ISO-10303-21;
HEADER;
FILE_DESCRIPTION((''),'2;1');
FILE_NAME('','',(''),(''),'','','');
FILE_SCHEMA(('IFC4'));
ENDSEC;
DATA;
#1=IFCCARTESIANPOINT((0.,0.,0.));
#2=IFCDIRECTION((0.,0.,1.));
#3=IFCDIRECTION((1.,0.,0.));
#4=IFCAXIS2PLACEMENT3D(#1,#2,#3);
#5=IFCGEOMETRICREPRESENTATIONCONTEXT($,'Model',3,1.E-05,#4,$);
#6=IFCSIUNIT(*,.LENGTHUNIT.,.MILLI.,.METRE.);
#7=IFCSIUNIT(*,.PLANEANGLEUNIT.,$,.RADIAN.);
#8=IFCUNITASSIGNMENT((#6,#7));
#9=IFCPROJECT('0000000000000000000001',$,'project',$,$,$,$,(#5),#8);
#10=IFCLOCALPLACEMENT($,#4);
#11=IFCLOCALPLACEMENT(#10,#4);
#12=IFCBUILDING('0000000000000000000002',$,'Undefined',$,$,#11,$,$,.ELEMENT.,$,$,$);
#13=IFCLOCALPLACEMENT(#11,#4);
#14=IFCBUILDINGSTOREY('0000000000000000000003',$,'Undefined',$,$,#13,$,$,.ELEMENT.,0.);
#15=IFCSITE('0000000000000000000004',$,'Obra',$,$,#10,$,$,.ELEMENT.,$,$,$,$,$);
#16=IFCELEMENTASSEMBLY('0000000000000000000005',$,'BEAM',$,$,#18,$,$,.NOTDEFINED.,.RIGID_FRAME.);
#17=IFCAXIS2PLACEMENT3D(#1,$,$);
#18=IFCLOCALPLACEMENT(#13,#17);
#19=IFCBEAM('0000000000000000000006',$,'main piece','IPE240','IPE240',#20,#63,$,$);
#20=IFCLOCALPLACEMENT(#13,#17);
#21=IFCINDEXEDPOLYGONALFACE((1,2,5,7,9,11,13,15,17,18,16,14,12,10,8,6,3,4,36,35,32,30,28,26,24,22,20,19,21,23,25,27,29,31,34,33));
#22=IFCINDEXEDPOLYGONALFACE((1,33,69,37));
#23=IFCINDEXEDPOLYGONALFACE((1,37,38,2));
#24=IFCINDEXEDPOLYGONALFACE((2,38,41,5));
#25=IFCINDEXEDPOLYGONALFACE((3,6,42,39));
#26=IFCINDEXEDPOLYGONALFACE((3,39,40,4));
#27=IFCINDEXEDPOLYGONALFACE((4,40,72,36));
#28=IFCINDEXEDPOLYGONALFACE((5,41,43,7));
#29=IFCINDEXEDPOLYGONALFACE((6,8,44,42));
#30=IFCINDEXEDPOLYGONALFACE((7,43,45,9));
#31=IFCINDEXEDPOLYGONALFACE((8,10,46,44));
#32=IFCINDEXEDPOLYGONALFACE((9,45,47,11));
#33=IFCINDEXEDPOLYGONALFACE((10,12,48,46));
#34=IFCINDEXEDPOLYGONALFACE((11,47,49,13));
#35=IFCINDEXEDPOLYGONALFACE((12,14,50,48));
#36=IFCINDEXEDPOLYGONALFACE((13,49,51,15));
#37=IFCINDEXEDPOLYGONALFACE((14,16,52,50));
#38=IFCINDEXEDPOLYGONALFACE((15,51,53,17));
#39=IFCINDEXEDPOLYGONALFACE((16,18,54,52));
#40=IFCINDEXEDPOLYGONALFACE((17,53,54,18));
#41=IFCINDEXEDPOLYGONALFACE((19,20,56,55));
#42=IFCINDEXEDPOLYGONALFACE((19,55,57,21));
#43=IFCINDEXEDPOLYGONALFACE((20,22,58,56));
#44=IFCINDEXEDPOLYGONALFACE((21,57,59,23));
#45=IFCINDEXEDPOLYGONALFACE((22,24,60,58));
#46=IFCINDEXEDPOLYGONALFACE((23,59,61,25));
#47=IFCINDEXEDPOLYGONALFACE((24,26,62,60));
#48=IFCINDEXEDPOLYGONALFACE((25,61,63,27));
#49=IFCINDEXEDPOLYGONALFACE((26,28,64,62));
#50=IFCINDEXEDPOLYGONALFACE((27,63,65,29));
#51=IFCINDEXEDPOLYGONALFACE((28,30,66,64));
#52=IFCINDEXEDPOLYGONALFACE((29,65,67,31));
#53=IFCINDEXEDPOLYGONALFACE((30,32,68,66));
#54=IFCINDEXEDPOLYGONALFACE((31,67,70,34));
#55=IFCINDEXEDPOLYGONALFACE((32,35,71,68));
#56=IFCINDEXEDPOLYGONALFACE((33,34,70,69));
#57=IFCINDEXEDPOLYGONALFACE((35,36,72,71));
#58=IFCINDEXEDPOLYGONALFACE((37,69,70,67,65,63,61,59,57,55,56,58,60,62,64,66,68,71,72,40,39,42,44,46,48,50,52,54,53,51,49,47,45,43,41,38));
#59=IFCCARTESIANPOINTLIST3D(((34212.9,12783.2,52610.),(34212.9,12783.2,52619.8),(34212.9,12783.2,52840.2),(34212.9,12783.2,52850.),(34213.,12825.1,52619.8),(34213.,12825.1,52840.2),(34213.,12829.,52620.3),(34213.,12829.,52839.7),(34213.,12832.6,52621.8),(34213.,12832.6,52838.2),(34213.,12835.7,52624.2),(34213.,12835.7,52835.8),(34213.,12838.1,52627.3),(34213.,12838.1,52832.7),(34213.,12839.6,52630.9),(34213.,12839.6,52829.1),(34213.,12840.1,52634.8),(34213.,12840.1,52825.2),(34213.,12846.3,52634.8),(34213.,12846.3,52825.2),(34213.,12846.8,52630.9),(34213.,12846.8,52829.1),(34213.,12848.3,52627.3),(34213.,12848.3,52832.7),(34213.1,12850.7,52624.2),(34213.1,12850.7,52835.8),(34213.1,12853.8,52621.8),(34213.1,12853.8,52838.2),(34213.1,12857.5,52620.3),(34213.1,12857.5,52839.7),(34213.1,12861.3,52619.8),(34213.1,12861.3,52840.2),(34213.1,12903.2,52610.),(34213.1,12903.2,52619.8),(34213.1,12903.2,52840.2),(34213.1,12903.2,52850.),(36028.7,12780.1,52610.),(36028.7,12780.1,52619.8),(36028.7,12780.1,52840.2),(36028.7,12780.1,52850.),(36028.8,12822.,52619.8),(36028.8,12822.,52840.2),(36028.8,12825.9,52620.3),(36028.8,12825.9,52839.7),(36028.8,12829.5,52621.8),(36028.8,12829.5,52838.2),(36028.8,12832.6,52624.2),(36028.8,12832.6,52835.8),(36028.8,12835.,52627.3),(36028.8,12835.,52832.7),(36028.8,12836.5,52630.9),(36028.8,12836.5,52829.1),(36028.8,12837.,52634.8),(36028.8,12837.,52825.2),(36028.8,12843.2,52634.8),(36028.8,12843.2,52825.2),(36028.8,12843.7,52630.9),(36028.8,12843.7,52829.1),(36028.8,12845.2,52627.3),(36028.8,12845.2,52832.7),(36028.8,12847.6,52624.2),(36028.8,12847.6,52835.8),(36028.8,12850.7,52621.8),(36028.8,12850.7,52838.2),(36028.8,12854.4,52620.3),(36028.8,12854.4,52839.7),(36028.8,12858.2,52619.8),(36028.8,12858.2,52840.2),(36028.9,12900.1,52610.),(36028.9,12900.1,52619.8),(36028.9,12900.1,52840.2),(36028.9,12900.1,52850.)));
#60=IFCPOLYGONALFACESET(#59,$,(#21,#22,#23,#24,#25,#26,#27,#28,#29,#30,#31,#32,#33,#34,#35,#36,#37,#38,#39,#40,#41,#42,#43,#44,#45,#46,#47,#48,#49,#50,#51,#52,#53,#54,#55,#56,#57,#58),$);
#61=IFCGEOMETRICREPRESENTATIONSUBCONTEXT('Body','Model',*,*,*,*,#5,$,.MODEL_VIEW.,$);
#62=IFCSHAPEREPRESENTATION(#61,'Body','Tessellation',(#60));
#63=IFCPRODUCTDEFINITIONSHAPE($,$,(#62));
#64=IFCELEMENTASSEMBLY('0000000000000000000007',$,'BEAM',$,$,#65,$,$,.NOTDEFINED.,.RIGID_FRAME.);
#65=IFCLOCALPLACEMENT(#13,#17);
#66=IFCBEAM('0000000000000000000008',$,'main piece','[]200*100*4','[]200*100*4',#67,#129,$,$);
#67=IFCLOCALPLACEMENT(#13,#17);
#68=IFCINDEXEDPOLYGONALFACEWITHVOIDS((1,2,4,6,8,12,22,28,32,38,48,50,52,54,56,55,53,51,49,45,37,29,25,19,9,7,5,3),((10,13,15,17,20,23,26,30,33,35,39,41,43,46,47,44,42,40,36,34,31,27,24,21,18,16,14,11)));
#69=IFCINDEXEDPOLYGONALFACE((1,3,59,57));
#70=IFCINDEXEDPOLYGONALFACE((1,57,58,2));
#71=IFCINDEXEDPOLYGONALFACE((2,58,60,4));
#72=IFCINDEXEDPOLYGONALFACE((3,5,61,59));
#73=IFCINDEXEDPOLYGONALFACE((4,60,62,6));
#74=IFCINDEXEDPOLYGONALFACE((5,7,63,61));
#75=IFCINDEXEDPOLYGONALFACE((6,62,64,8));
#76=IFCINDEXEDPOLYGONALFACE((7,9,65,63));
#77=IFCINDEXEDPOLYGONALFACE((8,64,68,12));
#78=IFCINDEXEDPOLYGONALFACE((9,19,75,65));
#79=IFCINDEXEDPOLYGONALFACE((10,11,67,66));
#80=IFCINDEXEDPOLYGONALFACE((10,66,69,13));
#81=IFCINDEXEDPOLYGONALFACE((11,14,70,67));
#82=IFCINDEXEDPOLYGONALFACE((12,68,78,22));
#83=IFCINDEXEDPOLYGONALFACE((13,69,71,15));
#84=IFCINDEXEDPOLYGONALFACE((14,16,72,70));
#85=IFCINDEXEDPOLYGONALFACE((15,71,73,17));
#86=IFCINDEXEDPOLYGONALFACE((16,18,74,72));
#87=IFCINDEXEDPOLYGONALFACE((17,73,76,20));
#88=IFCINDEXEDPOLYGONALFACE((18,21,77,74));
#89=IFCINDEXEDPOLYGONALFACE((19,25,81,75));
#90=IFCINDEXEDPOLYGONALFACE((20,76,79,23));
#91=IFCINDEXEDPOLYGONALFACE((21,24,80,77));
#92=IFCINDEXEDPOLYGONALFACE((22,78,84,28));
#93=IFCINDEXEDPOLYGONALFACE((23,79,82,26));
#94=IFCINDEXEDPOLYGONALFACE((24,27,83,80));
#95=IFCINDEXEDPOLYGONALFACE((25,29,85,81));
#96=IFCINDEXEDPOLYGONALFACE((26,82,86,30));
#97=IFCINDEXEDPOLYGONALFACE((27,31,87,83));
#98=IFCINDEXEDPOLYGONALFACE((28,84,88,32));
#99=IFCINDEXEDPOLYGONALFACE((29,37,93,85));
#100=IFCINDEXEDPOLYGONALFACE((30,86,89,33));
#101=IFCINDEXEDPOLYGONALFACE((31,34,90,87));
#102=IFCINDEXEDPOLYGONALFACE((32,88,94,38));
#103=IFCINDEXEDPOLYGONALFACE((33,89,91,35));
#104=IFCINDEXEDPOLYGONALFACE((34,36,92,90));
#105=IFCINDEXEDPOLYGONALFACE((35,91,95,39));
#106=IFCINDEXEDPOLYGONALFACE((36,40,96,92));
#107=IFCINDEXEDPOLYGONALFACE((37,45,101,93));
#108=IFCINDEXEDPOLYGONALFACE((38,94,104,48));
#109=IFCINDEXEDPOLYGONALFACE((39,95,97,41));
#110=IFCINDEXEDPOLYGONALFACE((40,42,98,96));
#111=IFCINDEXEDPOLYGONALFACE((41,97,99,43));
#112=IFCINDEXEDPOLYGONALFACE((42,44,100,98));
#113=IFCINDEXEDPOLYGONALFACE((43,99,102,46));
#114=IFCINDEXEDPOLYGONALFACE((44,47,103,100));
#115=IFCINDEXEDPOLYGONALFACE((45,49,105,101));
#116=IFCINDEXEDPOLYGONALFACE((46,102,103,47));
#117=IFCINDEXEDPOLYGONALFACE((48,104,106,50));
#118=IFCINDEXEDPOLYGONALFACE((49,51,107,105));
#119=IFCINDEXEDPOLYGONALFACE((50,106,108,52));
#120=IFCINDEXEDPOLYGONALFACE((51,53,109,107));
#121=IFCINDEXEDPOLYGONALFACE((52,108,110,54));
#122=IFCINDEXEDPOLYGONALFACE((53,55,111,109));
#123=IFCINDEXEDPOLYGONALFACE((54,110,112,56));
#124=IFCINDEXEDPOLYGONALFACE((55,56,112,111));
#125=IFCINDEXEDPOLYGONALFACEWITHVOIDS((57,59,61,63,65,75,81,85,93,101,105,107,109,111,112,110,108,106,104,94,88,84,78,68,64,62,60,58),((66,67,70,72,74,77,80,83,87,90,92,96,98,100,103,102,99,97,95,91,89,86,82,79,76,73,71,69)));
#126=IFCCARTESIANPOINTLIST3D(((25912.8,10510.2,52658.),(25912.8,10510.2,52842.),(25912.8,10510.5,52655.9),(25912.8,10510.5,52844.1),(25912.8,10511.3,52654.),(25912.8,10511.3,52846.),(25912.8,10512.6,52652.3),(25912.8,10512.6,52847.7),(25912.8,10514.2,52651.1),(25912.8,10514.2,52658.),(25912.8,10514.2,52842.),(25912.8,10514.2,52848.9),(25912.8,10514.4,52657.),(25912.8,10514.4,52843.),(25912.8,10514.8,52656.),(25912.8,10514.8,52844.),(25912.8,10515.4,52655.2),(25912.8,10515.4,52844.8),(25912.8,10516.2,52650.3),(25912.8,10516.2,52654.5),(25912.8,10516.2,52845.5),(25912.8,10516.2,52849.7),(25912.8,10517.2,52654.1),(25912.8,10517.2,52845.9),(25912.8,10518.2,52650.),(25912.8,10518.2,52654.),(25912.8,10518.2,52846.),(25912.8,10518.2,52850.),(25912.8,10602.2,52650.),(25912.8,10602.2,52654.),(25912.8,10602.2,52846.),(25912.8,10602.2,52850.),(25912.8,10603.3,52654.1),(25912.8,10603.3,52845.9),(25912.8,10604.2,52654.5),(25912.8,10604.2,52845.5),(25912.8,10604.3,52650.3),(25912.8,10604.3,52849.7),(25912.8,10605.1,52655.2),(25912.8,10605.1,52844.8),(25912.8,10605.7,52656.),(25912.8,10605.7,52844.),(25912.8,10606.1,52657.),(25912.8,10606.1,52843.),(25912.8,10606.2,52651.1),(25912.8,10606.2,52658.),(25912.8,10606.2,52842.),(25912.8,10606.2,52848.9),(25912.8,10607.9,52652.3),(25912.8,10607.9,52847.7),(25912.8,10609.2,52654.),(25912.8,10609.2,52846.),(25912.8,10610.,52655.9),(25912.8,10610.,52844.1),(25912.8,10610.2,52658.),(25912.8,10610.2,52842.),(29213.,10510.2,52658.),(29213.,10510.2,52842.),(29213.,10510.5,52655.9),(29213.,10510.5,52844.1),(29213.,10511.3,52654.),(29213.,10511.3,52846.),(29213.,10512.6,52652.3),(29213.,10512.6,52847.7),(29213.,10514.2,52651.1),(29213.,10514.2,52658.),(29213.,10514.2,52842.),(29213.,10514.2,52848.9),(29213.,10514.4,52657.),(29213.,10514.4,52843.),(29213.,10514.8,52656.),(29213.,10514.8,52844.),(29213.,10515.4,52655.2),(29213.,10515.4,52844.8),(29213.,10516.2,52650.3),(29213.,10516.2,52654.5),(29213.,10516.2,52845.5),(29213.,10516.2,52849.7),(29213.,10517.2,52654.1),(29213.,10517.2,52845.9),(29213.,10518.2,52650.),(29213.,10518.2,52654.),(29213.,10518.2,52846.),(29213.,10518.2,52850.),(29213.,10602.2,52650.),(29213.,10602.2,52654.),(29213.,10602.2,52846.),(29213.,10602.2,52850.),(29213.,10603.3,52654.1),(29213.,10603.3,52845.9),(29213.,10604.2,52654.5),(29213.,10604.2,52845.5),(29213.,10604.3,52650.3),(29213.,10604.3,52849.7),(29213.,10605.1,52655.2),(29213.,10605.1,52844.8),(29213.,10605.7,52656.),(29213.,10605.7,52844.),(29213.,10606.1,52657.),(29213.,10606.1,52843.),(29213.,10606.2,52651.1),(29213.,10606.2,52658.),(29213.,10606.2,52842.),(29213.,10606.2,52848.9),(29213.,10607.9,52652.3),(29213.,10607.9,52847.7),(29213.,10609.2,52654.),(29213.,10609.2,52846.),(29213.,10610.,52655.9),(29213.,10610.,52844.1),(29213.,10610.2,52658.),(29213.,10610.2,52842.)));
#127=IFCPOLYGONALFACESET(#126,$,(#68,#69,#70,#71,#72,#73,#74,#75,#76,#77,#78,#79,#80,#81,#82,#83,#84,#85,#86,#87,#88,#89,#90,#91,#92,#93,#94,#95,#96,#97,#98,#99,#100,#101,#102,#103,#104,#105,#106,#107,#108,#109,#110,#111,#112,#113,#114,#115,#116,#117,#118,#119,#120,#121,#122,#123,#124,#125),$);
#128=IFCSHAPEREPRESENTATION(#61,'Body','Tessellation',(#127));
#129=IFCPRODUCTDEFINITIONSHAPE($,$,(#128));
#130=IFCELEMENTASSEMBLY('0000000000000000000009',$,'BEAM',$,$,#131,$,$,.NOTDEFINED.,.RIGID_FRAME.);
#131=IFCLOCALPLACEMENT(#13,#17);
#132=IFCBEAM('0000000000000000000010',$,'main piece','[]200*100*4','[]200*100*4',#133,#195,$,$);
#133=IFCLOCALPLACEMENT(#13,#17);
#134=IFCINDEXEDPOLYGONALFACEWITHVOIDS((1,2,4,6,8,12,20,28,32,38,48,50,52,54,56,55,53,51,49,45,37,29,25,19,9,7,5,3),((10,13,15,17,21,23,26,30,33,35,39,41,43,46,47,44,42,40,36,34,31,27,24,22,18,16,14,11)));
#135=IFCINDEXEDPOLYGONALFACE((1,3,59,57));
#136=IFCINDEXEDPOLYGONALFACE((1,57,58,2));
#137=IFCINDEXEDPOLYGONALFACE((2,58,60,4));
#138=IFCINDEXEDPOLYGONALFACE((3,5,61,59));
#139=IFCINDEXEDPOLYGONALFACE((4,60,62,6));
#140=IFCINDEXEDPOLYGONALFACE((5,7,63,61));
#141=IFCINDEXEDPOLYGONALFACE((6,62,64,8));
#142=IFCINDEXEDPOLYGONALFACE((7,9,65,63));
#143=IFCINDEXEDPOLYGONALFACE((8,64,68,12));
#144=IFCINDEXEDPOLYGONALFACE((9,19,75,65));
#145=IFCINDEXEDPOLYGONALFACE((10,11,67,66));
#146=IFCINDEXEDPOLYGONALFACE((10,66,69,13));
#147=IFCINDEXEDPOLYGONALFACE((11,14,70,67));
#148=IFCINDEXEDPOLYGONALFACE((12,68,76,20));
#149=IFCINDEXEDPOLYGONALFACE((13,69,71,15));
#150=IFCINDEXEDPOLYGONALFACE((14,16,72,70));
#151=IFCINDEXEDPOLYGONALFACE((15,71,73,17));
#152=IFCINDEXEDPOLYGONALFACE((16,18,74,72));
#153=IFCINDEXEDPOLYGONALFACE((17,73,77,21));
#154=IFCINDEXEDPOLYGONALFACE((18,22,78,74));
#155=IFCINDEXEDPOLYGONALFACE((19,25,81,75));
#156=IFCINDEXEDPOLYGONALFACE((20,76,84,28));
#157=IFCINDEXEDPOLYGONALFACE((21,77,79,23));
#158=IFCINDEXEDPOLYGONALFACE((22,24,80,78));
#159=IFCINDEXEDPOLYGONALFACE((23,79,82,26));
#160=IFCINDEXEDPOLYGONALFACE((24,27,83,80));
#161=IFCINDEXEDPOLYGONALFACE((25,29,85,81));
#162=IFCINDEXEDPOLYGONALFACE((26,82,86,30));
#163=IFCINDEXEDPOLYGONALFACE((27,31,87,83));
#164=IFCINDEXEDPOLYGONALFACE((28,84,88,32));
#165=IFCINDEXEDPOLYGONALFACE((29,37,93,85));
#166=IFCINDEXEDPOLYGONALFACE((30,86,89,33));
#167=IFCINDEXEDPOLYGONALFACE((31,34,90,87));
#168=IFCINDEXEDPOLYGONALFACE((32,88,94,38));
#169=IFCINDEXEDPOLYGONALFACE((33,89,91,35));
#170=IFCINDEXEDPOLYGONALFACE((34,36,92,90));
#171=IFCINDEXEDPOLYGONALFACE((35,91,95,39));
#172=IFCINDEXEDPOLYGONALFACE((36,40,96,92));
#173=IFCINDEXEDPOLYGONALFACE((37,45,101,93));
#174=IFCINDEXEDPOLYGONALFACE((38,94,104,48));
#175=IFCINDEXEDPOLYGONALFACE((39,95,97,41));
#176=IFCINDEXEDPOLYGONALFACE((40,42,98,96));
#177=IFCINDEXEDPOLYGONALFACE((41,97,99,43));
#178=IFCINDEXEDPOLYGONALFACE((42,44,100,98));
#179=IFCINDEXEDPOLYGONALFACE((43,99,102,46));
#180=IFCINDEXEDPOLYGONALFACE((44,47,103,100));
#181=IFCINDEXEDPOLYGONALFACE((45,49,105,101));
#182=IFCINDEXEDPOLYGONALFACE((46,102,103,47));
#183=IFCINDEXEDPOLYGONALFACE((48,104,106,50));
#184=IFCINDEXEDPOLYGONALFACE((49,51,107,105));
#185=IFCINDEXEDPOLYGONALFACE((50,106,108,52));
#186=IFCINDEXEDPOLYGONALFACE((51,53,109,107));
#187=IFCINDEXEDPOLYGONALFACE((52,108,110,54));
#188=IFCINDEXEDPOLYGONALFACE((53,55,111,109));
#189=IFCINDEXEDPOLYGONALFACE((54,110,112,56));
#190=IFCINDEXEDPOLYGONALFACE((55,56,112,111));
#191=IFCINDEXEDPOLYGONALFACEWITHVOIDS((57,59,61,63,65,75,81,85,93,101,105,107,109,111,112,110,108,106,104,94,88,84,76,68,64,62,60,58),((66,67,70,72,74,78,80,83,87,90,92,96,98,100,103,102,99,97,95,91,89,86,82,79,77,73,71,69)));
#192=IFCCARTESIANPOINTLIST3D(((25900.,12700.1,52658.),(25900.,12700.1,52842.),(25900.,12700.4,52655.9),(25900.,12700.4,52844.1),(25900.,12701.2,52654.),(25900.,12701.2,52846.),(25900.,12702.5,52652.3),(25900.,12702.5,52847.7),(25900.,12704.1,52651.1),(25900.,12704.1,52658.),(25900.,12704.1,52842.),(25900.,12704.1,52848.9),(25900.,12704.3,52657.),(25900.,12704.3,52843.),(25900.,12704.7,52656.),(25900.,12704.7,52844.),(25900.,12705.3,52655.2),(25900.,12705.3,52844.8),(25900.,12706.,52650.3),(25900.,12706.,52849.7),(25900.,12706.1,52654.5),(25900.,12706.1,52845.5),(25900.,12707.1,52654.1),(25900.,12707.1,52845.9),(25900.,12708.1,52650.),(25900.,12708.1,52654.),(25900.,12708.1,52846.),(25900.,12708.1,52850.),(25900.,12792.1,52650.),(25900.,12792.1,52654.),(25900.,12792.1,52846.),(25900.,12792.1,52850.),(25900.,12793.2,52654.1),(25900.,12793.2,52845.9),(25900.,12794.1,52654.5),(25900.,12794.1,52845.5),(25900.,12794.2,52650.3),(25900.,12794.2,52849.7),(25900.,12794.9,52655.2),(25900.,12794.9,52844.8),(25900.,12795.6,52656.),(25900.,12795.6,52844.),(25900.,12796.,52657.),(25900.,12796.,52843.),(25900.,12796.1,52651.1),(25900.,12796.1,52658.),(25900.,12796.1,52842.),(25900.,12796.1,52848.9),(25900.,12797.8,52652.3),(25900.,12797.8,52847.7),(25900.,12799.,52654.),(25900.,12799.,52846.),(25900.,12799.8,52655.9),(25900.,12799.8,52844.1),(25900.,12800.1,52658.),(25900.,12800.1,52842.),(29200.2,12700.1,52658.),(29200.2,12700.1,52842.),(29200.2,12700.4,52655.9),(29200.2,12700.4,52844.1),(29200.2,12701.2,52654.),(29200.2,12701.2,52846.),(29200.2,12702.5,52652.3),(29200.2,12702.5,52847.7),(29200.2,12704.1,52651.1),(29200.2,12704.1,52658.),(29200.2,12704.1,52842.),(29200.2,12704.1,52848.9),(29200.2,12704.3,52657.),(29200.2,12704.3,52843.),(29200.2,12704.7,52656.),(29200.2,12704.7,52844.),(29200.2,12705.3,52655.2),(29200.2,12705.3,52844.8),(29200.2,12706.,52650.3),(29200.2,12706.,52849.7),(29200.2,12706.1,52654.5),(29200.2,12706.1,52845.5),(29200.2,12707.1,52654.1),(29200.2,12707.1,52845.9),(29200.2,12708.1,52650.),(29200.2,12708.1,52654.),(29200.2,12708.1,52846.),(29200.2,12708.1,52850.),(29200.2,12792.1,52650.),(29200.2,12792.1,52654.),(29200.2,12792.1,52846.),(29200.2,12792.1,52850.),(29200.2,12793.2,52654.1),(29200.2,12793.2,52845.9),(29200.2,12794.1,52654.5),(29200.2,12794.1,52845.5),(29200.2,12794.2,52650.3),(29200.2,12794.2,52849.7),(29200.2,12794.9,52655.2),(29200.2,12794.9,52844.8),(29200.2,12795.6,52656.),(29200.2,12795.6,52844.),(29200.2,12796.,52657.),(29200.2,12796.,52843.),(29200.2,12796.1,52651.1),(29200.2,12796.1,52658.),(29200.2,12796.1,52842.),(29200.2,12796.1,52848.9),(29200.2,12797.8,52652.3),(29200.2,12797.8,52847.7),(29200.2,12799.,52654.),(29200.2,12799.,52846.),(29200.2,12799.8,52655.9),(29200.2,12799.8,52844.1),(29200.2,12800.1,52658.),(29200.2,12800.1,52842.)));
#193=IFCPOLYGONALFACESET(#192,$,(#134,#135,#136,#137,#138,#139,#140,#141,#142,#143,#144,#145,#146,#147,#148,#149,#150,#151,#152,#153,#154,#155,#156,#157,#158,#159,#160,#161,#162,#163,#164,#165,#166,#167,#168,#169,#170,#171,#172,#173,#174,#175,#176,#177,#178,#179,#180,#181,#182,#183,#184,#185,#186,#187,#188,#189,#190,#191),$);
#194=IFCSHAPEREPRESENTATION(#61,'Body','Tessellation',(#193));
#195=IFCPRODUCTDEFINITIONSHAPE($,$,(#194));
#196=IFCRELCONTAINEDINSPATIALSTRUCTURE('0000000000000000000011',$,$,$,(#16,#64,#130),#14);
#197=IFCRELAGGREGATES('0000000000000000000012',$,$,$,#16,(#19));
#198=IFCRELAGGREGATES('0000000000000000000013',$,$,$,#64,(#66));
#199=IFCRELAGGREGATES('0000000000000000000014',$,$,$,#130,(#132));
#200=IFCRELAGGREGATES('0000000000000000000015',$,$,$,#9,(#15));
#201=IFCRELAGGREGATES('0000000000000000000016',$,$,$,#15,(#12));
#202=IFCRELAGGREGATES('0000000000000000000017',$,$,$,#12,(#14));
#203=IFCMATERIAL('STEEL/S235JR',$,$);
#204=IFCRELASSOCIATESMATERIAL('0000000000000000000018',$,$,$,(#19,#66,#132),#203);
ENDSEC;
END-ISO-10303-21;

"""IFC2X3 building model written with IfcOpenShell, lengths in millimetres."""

from ifc_helpers import new_model, si_unit, frame, origin_with_axes, origin_2d_with_axis, place, context, subcontext, project, spatial, hollow_rectangle, i_section, extrude, material, element, aggregate, save


model = new_model("IFC2X3")

# Units and contexts
model_context = context("Model", 3, precision=1e-05, world=origin_with_axes())
body_context = subcontext(model_context, "Body", "Model", "MODEL_VIEW")
ifc_project = project(units=[si_unit("LENGTHUNIT", "METRE", prefix="MILLI"), si_unit("PLANEANGLEUNIT", "RADIAN")], contexts=[model_context])

# Site, building, storey
site_placement = place(None, origin_with_axes())
site = spatial("IfcSite", under=ifc_project, at=site_placement, Name="Obra", CompositionType="ELEMENT")
building_placement = place(site_placement, origin_with_axes())
building = spatial("IfcBuilding", under=site, at=building_placement, Name="Undefined", CompositionType="ELEMENT")
storey_placement = place(building_placement, origin_with_axes())
storey = spatial("IfcBuildingStorey", under=building, at=storey_placement, Name="Undefined", CompositionType="ELEMENT", Elevation=0.0)

# Shared definitions
ifc_material_1 = material(Name="STEEL/S235JR")

# Element assemblies, beams
assembly_1_placement = place(storey_placement, origin_with_axes())
assembly_1 = element("IfcElementAssembly", 1, at=assembly_1_placement, inside=storey, Name="BEAM", AssemblyPlace="NOTDEFINED", PredefinedType="RIGID_FRAME")
beam_1_placement = place(assembly_1_placement, frame((34213.0, 12843.2, 52730.0), z_axis=(0.0, 0.0, 1.0), x_axis=(0.999999, -0.001707, 0.0)))
beam_1 = element("IfcBeam", 2, at=beam_1_placement, material=ifc_material_1, Name="main piece", Description="IPE240", ObjectType="IPE240", context=body_context, shape_type="SweptSolid", body=[
    extrude(i_section(OverallWidth=120.0, OverallDepth=240.0, WebThickness=6.2, FlangeThickness=9.8, FilletRadius=15.0, at=origin_2d_with_axis()), frame((1815.7, 0.0, 0.0), z_axis=(-1.0, 0.0, 0.0), x_axis=(0.0, -1.0, 0.0)), (0.0, 0.0, 1.0), 1815.8),
])
aggregate(assembly_1, [beam_1])
assembly_2_placement = place(storey_placement, origin_with_axes())
assembly_2 = element("IfcElementAssembly", 3, at=assembly_2_placement, inside=storey, Name="BEAM", AssemblyPlace="NOTDEFINED", PredefinedType="RIGID_FRAME")
beam_2_placement = place(assembly_2_placement, frame((25912.8, 10560.2, 52750.0), z_axis=(0.0, 0.0, 1.0), x_axis=(1.0, 0.0, 0.0)))
beam_2 = element("IfcBeam", 4, at=beam_2_placement, material=ifc_material_1, Name="main piece", Description="[]200*100*4", ObjectType="[]200*100*4", context=body_context, shape_type="SweptSolid", body=[
    extrude(hollow_rectangle(XDim=100.0, YDim=200.0, WallThickness=4.0, InnerFilletRadius=4.0, OuterFilletRadius=8.0, at=origin_2d_with_axis()), frame((3300.2, 0.0, 0.0), z_axis=(-1.0, 0.0, 0.0), x_axis=(0.0, -1.0, 0.0)), (0.0, 0.0, 1.0), 3300.2),
])
aggregate(assembly_2, [beam_2])
assembly_3_placement = place(storey_placement, origin_with_axes())
assembly_3 = element("IfcElementAssembly", 5, at=assembly_3_placement, inside=storey, Name="BEAM", AssemblyPlace="NOTDEFINED", PredefinedType="RIGID_FRAME")
beam_3_placement = place(assembly_3_placement, frame((25900.1, 12750.1, 52750.0), z_axis=(0.0, 0.0, 1.0), x_axis=(1.0, 0.0, 0.0)))
beam_3 = element("IfcBeam", 6, at=beam_3_placement, material=ifc_material_1, Name="main piece", Description="[]200*100*4", ObjectType="[]200*100*4", context=body_context, shape_type="SweptSolid", body=[
    extrude(hollow_rectangle(XDim=100.0, YDim=200.0, WallThickness=4.0, InnerFilletRadius=4.0, OuterFilletRadius=8.0, at=origin_2d_with_axis()), frame((3300.2, 0.0, 0.0), z_axis=(-1.0, 0.0, 0.0), x_axis=(0.0, -1.0, 0.0)), (0.0, 0.0, 1.0), 3300.2),
])
aggregate(assembly_3, [beam_3])

save(model, "model.ifc")
